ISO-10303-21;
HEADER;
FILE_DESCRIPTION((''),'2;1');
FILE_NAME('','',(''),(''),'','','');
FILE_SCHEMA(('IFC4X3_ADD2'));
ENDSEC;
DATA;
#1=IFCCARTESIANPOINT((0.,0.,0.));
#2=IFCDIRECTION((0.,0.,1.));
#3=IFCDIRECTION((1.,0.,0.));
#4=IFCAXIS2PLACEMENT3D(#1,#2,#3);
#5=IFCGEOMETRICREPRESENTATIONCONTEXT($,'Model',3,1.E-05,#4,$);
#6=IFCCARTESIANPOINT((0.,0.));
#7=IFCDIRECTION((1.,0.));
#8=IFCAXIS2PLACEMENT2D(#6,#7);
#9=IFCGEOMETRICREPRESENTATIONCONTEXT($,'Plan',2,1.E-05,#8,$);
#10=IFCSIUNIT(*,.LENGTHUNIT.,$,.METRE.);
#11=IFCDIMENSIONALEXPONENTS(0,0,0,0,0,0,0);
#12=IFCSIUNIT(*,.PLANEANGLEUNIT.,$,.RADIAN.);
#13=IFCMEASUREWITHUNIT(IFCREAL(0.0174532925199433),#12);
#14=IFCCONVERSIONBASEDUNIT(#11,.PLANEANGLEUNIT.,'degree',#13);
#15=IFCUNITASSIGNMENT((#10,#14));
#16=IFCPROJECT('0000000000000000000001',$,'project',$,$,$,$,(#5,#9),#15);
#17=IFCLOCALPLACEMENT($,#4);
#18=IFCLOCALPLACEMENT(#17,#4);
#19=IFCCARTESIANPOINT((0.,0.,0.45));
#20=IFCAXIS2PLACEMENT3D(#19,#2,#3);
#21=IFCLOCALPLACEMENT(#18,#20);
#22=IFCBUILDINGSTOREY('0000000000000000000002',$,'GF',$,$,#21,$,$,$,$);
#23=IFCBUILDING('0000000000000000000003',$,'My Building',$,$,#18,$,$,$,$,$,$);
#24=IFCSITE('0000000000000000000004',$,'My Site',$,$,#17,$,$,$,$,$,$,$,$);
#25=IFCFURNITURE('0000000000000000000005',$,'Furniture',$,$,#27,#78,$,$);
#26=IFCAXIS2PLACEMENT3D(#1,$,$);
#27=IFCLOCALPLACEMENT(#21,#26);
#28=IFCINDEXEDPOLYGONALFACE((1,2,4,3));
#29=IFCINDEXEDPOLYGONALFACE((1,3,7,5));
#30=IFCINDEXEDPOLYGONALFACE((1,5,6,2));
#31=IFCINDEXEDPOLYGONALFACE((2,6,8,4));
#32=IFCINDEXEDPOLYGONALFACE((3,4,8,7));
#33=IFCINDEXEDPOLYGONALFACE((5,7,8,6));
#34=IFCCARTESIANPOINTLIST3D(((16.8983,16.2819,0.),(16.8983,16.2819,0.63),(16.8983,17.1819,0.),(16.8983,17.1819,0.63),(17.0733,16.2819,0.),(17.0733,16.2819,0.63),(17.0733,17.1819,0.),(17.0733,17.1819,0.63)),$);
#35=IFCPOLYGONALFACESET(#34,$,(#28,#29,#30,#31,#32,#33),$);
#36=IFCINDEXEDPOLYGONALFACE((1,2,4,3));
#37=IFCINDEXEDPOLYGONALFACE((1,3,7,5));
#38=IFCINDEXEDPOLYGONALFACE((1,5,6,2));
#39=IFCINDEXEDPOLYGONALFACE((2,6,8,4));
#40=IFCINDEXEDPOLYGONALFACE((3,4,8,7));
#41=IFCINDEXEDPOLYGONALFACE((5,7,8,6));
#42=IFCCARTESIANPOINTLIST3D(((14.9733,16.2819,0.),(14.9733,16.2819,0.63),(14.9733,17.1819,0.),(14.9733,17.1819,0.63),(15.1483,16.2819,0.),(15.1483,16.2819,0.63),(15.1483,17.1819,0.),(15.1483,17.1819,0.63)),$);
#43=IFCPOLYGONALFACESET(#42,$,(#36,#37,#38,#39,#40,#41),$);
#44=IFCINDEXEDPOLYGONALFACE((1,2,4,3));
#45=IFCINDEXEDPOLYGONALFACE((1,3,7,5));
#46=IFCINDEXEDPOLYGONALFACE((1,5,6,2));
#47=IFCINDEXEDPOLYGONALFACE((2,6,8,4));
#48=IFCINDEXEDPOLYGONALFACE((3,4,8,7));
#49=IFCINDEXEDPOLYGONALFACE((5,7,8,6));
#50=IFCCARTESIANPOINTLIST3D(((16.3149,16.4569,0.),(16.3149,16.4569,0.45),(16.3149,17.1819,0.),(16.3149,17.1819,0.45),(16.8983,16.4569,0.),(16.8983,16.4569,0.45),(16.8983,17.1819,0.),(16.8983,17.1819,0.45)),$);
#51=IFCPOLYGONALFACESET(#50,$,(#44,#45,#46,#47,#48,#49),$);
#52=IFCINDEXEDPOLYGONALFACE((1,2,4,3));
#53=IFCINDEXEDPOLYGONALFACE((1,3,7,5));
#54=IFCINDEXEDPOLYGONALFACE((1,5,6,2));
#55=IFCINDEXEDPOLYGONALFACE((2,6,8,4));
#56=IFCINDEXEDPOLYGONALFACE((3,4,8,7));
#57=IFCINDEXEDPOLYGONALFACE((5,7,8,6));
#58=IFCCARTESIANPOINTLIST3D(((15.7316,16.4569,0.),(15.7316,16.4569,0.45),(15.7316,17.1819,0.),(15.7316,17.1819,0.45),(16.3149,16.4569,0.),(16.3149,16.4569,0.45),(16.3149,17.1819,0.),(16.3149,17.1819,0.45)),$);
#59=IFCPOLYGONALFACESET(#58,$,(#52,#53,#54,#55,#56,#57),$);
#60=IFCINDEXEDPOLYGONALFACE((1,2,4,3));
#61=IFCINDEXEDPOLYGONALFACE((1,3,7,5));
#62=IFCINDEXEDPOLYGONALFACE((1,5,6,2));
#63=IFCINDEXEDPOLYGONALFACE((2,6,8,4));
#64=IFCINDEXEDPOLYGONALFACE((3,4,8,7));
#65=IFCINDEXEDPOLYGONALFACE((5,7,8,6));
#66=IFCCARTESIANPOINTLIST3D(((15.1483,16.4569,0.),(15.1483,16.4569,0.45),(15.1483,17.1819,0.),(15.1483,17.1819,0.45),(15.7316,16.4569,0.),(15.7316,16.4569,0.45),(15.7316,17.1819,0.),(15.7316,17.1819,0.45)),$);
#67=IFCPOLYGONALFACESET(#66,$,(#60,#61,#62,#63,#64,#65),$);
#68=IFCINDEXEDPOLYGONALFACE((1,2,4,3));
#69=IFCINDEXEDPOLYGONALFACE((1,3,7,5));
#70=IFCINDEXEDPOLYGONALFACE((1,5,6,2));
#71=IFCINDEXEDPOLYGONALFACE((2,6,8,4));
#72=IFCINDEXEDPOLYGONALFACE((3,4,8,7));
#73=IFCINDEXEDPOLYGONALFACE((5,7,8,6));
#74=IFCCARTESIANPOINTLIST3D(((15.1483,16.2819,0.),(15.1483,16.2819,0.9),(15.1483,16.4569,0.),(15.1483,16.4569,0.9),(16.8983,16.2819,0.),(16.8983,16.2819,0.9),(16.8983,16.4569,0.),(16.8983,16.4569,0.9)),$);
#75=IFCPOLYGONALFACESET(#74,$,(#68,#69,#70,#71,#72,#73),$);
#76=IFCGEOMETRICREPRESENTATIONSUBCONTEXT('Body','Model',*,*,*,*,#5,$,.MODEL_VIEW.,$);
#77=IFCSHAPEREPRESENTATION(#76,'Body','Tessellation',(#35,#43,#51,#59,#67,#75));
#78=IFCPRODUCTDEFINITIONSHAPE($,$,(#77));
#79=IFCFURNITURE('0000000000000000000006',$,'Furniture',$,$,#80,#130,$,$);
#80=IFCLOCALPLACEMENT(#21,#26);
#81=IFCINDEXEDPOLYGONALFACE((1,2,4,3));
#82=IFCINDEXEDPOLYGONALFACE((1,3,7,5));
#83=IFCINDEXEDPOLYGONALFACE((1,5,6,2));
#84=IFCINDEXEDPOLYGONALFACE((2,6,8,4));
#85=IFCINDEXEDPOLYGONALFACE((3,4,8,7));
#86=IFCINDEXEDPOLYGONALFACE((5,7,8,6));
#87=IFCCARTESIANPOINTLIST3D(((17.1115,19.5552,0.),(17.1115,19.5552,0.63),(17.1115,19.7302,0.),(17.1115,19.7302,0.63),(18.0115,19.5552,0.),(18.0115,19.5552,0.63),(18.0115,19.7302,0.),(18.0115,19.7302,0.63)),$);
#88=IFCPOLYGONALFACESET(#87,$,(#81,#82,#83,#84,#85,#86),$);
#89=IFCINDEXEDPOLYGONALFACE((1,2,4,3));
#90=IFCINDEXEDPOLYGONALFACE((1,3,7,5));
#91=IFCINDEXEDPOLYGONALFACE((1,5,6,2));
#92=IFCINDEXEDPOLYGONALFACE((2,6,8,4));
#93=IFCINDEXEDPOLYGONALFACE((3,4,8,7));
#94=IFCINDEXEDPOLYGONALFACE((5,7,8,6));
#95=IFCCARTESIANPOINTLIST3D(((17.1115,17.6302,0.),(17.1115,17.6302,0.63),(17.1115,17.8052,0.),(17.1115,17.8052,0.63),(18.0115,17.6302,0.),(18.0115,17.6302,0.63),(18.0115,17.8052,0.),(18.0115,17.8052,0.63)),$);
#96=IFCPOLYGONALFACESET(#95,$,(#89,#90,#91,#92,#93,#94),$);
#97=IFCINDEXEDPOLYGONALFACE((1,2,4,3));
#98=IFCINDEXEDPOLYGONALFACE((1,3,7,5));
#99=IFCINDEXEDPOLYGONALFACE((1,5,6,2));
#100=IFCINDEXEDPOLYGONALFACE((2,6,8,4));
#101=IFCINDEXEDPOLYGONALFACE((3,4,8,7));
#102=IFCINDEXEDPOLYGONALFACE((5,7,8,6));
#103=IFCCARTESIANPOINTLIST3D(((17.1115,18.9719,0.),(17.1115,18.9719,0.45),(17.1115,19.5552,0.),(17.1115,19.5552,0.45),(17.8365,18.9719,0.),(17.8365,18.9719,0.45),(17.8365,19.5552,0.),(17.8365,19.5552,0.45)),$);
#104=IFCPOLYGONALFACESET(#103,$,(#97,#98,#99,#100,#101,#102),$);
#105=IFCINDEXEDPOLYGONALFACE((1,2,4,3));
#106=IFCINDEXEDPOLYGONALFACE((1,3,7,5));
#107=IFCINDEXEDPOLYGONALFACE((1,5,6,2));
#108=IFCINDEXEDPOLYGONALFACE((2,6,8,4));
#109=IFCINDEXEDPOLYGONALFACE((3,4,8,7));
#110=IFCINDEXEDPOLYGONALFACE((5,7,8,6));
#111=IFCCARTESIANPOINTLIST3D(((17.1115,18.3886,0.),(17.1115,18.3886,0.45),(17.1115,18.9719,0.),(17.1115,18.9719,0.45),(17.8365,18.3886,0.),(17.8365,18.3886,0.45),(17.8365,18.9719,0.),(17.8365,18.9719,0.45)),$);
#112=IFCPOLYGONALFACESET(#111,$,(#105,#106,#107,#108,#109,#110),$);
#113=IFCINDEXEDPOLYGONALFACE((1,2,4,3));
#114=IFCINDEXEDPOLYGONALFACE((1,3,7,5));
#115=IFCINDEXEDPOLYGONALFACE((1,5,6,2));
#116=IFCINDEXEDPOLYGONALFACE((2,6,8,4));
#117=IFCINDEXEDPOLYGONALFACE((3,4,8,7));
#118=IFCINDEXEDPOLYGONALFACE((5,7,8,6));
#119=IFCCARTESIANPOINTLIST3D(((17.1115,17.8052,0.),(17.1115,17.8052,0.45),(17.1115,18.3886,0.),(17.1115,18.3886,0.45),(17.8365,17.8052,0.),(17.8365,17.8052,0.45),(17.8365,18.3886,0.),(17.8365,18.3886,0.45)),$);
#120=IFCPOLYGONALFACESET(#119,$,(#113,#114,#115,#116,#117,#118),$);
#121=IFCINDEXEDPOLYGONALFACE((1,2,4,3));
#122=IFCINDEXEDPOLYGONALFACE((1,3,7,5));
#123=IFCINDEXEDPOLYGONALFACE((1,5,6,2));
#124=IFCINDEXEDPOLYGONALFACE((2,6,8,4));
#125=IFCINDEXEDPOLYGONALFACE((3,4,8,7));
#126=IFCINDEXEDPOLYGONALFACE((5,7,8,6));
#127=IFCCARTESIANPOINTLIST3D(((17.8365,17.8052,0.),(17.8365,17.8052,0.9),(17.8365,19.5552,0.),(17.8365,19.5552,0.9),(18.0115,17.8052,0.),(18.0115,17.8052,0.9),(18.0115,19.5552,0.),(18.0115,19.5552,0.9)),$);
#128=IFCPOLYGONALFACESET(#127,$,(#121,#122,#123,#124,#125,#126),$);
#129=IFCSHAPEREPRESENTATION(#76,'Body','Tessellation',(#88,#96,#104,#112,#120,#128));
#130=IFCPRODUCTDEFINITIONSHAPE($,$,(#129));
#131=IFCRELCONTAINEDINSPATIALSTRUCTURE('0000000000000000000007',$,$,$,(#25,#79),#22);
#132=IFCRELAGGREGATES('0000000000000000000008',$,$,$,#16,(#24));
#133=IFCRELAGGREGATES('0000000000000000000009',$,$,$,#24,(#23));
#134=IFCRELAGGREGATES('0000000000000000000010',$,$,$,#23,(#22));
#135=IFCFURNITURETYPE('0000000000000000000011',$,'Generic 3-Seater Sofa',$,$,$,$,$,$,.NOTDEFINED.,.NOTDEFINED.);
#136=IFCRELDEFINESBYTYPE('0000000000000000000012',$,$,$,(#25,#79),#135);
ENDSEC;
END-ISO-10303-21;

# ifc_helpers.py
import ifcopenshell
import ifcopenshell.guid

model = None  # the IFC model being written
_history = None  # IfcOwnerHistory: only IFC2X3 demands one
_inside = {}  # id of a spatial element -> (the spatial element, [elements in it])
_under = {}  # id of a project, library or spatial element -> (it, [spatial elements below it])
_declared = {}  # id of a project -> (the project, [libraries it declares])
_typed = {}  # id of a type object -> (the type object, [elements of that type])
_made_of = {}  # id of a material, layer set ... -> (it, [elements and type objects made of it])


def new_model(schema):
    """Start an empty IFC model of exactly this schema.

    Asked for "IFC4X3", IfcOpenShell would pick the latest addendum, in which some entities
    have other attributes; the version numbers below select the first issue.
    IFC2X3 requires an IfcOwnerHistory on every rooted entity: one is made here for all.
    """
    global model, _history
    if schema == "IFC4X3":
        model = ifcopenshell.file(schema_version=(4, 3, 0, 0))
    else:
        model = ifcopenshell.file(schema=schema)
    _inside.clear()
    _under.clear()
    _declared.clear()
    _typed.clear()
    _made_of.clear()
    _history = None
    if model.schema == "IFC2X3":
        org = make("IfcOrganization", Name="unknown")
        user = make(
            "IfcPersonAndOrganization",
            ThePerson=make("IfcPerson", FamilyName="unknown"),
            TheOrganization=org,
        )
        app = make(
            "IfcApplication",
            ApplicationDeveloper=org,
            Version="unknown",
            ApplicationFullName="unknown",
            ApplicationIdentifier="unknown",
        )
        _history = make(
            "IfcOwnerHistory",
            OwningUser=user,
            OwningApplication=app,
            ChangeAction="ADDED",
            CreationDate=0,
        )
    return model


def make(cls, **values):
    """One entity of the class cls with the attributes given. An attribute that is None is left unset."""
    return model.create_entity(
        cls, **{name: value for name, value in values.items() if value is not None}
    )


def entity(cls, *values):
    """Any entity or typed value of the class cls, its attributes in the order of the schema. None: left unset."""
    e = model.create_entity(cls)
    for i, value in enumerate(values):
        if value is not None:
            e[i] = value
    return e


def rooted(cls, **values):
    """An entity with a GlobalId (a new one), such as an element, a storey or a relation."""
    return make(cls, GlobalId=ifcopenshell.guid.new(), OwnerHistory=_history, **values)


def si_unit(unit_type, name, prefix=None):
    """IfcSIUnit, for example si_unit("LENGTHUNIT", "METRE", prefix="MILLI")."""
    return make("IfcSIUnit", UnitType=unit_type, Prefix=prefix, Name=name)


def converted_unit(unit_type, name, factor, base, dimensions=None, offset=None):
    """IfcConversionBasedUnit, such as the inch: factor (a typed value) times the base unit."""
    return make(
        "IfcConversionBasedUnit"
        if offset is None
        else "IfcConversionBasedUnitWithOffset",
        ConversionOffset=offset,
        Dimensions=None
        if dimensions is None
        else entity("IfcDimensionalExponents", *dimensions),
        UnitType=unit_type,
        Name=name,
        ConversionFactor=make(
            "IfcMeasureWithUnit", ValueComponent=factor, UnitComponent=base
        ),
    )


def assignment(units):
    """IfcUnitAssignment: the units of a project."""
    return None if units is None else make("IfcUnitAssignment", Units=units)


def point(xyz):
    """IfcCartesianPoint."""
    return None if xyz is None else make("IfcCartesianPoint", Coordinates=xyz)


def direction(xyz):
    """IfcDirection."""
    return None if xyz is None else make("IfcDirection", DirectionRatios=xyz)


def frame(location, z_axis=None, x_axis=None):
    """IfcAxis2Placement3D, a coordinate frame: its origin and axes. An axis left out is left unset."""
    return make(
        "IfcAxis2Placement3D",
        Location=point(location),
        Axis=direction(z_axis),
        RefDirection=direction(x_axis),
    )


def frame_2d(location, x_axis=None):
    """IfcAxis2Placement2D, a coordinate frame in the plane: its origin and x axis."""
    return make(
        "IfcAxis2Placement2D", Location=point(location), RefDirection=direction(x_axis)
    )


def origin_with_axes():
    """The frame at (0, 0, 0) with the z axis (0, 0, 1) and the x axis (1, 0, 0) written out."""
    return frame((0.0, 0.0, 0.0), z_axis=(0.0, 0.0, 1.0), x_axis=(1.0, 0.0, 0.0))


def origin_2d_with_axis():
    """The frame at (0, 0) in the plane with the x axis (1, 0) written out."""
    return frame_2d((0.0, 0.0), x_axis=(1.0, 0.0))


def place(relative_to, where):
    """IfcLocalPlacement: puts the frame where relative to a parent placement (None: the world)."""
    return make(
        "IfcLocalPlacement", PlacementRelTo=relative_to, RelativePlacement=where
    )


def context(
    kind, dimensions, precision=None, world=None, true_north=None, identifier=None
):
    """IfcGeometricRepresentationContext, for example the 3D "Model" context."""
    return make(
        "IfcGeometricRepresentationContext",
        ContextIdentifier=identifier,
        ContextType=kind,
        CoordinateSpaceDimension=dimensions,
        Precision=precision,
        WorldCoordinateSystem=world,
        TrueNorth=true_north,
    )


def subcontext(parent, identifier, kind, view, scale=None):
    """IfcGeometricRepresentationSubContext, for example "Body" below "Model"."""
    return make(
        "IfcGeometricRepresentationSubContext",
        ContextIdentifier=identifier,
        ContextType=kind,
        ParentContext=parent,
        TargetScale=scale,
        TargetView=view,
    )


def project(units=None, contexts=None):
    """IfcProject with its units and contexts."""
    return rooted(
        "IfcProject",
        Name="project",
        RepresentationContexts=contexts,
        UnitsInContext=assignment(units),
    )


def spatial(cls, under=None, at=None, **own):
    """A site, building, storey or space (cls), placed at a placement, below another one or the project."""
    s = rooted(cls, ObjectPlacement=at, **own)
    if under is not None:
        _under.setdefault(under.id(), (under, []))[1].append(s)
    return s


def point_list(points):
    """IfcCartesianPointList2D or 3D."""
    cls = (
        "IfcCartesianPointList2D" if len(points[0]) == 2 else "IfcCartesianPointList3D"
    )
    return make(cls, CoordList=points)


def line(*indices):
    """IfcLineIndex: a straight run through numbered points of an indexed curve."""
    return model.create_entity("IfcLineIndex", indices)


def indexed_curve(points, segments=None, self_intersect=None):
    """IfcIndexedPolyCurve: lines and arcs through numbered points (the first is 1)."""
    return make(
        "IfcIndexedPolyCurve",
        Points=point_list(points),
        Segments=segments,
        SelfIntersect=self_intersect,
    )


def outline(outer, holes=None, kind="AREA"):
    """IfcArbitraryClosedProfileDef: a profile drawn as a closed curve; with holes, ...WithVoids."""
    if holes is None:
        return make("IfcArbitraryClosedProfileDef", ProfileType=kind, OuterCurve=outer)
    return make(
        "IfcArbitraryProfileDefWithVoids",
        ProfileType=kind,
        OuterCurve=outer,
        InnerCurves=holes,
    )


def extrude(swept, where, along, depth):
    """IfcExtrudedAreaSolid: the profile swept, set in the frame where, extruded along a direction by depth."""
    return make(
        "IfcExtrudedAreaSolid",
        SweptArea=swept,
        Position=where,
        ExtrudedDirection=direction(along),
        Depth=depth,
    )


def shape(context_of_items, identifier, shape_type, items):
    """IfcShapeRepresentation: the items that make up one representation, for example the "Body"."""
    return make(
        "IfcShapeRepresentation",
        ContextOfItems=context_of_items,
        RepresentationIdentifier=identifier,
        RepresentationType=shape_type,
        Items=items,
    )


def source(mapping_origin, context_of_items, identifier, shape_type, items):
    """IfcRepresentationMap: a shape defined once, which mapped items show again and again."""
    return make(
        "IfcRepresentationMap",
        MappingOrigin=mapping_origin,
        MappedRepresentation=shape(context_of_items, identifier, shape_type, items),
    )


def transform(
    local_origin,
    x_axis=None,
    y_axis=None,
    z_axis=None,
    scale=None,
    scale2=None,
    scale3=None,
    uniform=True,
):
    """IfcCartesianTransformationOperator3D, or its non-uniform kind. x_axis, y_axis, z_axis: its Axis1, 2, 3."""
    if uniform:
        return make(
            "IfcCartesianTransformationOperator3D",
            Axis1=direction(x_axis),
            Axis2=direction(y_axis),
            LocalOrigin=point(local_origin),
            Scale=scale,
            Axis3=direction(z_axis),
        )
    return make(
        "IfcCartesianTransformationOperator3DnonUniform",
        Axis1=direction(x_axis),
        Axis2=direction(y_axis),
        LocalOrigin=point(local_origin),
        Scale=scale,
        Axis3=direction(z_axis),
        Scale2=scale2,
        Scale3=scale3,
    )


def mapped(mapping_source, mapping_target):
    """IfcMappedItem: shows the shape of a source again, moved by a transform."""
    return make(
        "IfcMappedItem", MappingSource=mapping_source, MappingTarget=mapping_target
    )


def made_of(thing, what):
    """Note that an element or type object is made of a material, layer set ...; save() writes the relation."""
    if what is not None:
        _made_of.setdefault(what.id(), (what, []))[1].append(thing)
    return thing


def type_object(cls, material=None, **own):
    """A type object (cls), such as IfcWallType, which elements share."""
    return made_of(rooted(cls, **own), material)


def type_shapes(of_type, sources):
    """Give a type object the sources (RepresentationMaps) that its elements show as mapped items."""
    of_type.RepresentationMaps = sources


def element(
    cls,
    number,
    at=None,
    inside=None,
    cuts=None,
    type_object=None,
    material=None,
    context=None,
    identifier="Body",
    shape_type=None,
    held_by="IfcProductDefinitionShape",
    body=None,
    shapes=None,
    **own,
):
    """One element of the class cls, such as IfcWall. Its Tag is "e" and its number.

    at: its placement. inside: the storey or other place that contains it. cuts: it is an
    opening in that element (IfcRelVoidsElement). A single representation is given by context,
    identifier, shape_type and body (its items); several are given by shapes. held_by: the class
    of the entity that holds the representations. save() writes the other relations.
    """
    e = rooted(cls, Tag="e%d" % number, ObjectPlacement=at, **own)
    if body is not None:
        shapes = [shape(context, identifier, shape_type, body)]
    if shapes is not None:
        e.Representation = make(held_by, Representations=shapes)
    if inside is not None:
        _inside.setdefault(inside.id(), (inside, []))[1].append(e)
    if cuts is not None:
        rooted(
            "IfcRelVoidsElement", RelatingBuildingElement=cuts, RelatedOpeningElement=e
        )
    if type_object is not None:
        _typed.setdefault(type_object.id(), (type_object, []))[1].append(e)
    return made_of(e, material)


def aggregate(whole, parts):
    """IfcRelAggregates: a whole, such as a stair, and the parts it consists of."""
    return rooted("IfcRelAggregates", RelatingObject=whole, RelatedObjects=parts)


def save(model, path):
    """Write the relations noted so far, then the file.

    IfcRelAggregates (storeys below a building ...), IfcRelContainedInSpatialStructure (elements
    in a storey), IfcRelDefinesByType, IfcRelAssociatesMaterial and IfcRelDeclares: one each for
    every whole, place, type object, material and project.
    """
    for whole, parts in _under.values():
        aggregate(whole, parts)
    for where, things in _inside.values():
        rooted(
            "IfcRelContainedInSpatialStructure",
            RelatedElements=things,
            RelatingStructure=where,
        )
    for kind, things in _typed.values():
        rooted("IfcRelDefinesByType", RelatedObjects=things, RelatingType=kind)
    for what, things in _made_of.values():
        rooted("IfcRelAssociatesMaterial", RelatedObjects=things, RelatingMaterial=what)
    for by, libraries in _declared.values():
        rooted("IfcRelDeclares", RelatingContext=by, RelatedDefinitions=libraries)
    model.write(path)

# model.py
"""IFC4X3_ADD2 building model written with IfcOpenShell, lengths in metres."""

from ifc_helpers import new_model, entity, si_unit, converted_unit, frame, origin_with_axes, origin_2d_with_axis, place, context, subcontext, project, spatial, line, indexed_curve, outline, extrude, shape, source, transform, mapped, type_object, type_shapes, element, save


model = new_model("IFC4X3_ADD2")

# Units and contexts
model_context = context("Model", 3, precision=1e-05, world=origin_with_axes())
plan_context = context("Plan", 2, precision=1e-05, world=origin_2d_with_axis())
body_context_1 = subcontext(model_context, "Body", "Model", "MODEL_VIEW")
body_context_2 = subcontext(plan_context, "Body", "Plan", "PLAN_VIEW")
ifc_project = project(units=[si_unit("LENGTHUNIT", "METRE"), converted_unit("PLANEANGLEUNIT", "degree", entity("IfcReal", 0.0174532925199433), si_unit("PLANEANGLEUNIT", "RADIAN"), dimensions=[0, 0, 0, 0, 0, 0, 0])], contexts=[model_context, plan_context])

# Site, building, storey
site_placement = place(None, origin_with_axes())
site = spatial("IfcSite", under=ifc_project, at=site_placement, Name="My Site")
building_placement = place(site_placement, origin_with_axes())
building = spatial("IfcBuilding", under=site, at=building_placement, Name="My Building")
storey_placement = place(building_placement, frame((0.0, 0.0, 0.45), z_axis=(0.0, 0.0, 1.0), x_axis=(1.0, 0.0, 0.0)))
storey = spatial("IfcBuildingStorey", under=building, at=storey_placement, Name="GF")

# Furniture
furniture_type_1 = type_object("IfcFurnitureType", Name="Generic 3-Seater Sofa", AssemblyPlace="NOTDEFINED", PredefinedType="NOTDEFINED")
shared_shape_1 = source(origin_with_axes(), body_context_1, "Body", "SweptSolid", [
    extrude(outline(indexed_curve([(0.0, 0.0), (0.175, 0.0), (0.175, 0.9), (0.0, 0.9)], segments=[line(1, 2, 3, 4, 1)])), frame((-1.05, -0.9, 0.0), z_axis=(0.0, 0.0, 1.0), x_axis=(1.0, 0.0, 0.0)), (0.0, 0.0, 1.0), 0.63),
    extrude(outline(indexed_curve([(0.0, 0.0), (0.175, 0.0), (0.175, 0.9), (0.0, 0.9)], segments=[line(1, 2, 3, 4, 1)])), frame((0.875, -0.9, 0.0), z_axis=(0.0, 0.0, 1.0), x_axis=(1.0, 0.0, 0.0)), (0.0, 0.0, 1.0), 0.63),
    extrude(outline(indexed_curve([(0.175, 0.0), (0.7583, 0.0), (0.7583, 0.725), (0.175, 0.725)], segments=[line(1, 2, 3, 4, 1)])), frame((-1.05, -0.9, 0.0), z_axis=(0.0, 0.0, 1.0), x_axis=(1.0, 0.0, 0.0)), (0.0, 0.0, 1.0), 0.45),
    extrude(outline(indexed_curve([(0.7583, 0.0), (1.3417, 0.0), (1.3417, 0.725), (0.7583, 0.725)], segments=[line(1, 2, 3, 4, 1)])), frame((-1.05, -0.9, 0.0), z_axis=(0.0, 0.0, 1.0), x_axis=(1.0, 0.0, 0.0)), (0.0, 0.0, 1.0), 0.45),
    extrude(outline(indexed_curve([(1.3417, 0.0), (1.925, 0.0), (1.925, 0.725), (1.3417, 0.725)], segments=[line(1, 2, 3, 4, 1)])), frame((-1.05, -0.9, 0.0), z_axis=(0.0, 0.0, 1.0), x_axis=(1.0, 0.0, 0.0)), (0.0, 0.0, 1.0), 0.45),
    extrude(outline(indexed_curve([(0.175, 0.725), (1.925, 0.725), (1.925, 0.9), (0.175, 0.9)], segments=[line(1, 2, 3, 4, 1)])), frame((-1.05, -0.9, 0.0), z_axis=(0.0, 0.0, 1.0), x_axis=(1.0, 0.0, 0.0)), (0.0, 0.0, 1.0), 0.9),
])
shared_shape_2 = source(origin_with_axes(), body_context_2, "Body", "Curve2D", [
    entity("IfcIndexedPolyCurve", entity("IfcCartesianPointList2D", [[-1.05, -0.9], [-0.875, -0.9], [-0.875, 0.0], [-1.05, 0.0]]), [entity("IfcLineIndex", [1, 2, 3, 4, 1])]),
    entity("IfcIndexedPolyCurve", entity("IfcCartesianPointList2D", [[0.875, -0.9], [1.05, -0.9], [1.05, 0.0], [0.875, 0.0]]), [entity("IfcLineIndex", [1, 2, 3, 4, 1])]),
    entity("IfcIndexedPolyCurve", entity("IfcCartesianPointList2D", [[-0.875, -0.9], [-0.2917, -0.9], [-0.2917, -0.175], [-0.875, -0.175]]), [entity("IfcLineIndex", [1, 2, 3, 4, 1])]),
    entity("IfcIndexedPolyCurve", entity("IfcCartesianPointList2D", [[-0.2917, -0.9], [0.2917, -0.9], [0.2917, -0.175], [-0.2917, -0.175]]), [entity("IfcLineIndex", [1, 2, 3, 4, 1])]),
    entity("IfcIndexedPolyCurve", entity("IfcCartesianPointList2D", [[0.2917, -0.9], [0.875, -0.9], [0.875, -0.175], [0.2917, -0.175]]), [entity("IfcLineIndex", [1, 2, 3, 4, 1])]),
    entity("IfcIndexedPolyCurve", entity("IfcCartesianPointList2D", [[-0.875, -0.175], [0.875, -0.175], [0.875, 0.0], [-0.875, 0.0]]), [entity("IfcLineIndex", [1, 2, 3, 4, 1])]),
])
type_shapes(furniture_type_1, [shared_shape_1, shared_shape_2])
for number, where, z_axis, x_axis, name in (
    (1, (16.0233, 16.2819, 0.0), (0.0, 0.0, 1.0), (-1.0, 0.0, 0.0), "Furniture"),
    (2, (18.0115, 18.6802, 0.0), (0.0, 0.0, 1.0), (0.0, -1.0, 0.0), "Furniture"),
):
    element("IfcFurniture", number, at=place(storey_placement, frame(where, z_axis=z_axis, x_axis=x_axis)), inside=storey, type_object=furniture_type_1, Name=name, shapes=[
        shape(body_context_1, "Body", "MappedRepresentation", [mapped(shared_shape_1, transform((0.0, 0.0, 0.0), x_axis=(1.0, 0.0, 0.0), y_axis=(0.0, 1.0, 0.0), z_axis=(0.0, 0.0, 1.0), scale=1.0))]),
        shape(body_context_2, "Body", "MappedRepresentation", [mapped(shared_shape_2, transform((0.0, 0.0, 0.0), x_axis=(1.0, 0.0, 0.0), y_axis=(0.0, 1.0, 0.0), z_axis=(0.0, 0.0, 1.0), scale=1.0))]),
    ])

save(model, "model.ifc")
